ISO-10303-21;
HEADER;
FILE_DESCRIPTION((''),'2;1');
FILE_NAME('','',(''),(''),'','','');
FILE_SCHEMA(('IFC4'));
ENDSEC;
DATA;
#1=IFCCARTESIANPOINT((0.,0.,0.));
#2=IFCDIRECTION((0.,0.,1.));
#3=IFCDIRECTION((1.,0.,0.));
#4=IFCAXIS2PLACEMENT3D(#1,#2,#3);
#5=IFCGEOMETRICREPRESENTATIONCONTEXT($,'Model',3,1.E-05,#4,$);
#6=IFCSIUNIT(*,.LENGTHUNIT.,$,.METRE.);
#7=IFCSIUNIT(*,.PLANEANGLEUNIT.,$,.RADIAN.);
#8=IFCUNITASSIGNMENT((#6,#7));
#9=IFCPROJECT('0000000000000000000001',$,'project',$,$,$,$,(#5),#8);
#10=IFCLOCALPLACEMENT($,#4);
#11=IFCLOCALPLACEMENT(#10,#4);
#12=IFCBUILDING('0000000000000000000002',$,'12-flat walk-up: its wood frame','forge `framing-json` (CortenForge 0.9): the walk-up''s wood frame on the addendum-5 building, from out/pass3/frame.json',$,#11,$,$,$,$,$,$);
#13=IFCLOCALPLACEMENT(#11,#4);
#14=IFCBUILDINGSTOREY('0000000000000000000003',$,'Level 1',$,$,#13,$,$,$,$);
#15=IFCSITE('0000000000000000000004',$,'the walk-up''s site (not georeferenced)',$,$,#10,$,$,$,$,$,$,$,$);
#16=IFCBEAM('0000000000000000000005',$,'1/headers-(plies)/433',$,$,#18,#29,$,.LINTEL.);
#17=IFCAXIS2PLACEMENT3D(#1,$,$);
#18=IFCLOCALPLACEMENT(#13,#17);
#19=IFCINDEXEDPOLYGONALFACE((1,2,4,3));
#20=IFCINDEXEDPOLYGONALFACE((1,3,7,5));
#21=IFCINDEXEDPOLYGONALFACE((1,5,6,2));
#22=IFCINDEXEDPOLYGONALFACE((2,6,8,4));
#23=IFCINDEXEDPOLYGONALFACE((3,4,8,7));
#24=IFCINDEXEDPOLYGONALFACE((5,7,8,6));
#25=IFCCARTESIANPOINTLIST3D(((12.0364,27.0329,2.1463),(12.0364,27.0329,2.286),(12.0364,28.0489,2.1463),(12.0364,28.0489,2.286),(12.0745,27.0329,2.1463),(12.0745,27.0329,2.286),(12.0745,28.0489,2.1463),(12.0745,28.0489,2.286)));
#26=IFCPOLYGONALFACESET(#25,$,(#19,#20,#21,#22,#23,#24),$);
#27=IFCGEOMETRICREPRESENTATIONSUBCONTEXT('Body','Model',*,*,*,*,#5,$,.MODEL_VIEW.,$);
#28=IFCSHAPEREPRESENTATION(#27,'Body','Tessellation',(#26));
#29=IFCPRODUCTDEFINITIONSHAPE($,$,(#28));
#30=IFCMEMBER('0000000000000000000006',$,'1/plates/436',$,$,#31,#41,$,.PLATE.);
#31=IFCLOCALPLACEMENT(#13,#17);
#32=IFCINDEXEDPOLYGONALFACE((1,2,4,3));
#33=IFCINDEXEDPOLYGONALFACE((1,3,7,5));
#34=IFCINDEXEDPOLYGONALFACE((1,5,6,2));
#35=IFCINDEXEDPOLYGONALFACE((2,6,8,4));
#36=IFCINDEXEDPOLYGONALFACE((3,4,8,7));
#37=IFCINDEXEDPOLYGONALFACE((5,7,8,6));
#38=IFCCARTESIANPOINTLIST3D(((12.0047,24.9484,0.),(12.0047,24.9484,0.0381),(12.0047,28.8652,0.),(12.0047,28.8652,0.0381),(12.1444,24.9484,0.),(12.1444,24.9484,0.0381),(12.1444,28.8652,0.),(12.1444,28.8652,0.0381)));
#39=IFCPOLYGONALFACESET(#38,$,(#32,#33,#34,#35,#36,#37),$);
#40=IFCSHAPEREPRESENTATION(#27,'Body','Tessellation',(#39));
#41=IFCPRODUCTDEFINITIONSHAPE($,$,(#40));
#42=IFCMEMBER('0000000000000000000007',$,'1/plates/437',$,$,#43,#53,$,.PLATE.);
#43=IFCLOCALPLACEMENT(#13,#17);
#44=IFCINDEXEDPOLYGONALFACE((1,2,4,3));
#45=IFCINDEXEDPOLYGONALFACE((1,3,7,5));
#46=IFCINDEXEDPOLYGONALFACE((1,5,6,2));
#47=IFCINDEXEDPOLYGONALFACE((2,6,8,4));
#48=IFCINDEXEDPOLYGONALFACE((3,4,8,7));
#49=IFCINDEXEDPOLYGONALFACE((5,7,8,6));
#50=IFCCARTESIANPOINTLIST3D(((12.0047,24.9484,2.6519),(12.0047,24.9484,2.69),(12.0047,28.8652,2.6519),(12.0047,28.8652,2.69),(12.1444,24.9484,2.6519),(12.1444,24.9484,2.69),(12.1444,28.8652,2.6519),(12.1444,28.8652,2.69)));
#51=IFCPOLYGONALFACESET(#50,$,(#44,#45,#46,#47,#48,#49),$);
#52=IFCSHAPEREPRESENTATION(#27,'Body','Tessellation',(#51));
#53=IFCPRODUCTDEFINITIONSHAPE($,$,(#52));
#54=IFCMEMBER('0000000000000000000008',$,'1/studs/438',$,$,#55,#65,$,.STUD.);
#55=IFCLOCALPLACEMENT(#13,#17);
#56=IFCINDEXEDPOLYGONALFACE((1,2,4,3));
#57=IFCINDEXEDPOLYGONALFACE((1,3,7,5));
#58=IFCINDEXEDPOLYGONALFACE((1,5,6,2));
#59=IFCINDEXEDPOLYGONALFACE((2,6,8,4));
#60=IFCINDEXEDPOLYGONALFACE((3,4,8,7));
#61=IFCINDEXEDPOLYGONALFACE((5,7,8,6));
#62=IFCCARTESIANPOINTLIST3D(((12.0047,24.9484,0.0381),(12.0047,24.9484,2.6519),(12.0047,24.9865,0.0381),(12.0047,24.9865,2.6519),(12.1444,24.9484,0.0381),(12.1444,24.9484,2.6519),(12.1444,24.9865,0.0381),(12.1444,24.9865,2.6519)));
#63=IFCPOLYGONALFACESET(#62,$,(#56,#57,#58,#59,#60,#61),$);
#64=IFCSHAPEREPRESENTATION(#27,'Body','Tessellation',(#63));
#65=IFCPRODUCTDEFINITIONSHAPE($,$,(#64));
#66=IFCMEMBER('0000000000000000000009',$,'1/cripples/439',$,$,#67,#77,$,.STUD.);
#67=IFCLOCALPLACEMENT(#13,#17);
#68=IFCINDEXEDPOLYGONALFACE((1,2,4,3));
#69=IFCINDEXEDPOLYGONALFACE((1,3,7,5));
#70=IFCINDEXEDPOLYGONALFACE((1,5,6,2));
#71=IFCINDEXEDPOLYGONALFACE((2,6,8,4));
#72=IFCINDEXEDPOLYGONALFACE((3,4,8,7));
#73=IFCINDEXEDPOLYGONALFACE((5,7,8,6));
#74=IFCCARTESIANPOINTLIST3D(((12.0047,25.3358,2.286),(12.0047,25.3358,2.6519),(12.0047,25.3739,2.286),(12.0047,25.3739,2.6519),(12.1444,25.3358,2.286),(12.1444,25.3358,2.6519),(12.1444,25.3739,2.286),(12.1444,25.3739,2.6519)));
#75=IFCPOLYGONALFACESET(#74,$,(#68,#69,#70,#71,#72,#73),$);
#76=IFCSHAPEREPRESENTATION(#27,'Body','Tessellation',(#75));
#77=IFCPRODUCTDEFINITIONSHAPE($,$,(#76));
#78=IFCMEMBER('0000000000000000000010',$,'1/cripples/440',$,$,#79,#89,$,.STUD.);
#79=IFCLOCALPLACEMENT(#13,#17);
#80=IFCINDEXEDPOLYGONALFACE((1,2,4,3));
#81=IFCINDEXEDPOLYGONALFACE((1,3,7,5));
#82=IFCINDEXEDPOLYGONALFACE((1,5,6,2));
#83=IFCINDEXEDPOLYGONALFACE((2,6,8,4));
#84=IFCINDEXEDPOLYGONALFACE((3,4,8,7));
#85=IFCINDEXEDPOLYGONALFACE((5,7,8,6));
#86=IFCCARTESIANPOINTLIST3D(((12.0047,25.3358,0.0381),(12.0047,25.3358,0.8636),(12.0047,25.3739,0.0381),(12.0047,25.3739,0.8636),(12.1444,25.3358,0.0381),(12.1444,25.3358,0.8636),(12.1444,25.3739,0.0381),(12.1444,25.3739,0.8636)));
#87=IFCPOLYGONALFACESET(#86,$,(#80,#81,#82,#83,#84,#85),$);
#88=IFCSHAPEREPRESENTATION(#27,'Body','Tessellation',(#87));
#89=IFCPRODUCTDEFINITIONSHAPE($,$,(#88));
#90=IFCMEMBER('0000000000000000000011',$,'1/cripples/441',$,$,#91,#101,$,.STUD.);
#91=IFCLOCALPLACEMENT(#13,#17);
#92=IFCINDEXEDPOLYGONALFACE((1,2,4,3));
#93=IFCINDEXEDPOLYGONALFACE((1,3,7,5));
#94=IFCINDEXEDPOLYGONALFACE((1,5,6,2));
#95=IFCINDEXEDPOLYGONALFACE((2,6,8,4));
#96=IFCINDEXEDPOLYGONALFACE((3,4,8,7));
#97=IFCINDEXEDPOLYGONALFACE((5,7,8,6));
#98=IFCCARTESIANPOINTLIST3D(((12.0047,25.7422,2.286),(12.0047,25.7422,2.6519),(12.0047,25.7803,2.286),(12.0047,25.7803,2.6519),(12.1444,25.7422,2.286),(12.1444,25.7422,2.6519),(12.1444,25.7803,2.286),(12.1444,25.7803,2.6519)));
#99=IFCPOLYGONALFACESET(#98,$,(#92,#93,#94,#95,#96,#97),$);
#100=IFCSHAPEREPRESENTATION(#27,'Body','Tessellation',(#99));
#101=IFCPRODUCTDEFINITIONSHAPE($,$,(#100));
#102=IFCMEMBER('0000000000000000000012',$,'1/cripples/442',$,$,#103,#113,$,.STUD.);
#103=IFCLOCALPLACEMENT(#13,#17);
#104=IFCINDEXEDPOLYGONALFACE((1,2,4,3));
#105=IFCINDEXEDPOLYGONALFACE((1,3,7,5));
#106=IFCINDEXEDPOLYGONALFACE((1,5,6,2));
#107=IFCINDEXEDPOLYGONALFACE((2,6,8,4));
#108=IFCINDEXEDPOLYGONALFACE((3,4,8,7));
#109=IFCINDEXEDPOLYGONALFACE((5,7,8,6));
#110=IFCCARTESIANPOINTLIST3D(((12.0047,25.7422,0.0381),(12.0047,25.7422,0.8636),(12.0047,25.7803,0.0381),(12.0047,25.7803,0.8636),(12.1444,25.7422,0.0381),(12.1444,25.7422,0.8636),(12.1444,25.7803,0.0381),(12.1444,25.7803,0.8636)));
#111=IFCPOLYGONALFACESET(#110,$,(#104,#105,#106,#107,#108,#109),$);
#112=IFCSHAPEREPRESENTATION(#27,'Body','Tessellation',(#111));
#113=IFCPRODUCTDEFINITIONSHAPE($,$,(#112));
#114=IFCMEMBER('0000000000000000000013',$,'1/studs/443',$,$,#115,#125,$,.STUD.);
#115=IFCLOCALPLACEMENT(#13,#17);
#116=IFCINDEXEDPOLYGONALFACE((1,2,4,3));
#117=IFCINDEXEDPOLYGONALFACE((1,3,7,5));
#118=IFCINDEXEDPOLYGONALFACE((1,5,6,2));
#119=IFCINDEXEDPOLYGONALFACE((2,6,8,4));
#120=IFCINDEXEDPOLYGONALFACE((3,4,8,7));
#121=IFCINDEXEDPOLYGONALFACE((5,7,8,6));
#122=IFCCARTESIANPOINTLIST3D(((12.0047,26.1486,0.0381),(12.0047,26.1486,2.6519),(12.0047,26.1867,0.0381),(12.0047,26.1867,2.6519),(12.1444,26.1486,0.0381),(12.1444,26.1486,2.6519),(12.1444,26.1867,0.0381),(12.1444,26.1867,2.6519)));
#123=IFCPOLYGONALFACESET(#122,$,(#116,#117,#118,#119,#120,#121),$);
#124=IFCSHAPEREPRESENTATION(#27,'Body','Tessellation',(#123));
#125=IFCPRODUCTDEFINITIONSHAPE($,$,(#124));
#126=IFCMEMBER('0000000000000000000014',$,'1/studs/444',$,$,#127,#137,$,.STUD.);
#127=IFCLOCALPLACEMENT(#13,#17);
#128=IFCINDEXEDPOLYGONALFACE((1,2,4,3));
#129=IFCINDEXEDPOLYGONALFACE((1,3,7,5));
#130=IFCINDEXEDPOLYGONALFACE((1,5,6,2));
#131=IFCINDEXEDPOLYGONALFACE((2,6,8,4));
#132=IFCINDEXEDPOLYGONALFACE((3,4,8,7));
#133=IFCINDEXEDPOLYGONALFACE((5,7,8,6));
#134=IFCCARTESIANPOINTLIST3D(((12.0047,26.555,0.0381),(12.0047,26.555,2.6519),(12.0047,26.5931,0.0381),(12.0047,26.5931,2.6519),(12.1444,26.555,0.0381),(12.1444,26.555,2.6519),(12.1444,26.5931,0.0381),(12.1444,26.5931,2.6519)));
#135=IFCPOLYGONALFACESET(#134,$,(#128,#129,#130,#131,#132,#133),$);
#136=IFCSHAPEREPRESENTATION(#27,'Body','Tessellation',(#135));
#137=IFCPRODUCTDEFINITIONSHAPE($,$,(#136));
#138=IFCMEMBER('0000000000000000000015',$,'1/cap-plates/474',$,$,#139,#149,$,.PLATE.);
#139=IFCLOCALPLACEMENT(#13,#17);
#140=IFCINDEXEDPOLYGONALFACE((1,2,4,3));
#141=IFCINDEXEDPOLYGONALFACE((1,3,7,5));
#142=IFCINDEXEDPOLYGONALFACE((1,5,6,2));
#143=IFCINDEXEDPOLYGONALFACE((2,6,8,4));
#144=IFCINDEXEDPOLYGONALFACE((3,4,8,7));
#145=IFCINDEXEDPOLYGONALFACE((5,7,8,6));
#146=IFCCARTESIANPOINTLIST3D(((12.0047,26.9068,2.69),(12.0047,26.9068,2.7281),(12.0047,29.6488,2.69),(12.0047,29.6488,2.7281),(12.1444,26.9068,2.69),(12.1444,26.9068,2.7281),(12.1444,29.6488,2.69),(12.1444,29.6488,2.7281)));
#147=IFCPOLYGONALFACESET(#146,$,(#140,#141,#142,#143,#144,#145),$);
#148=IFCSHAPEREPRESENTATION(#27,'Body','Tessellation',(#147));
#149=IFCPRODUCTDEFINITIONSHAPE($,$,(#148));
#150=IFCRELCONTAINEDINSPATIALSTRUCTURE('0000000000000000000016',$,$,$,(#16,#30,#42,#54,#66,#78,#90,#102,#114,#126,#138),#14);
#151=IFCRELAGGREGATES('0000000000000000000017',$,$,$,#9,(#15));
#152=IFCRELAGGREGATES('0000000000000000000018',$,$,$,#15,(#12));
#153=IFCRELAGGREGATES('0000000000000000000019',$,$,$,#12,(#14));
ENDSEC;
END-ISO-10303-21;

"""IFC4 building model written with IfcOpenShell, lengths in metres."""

from ifc_helpers import new_model, si_unit, frame, frame_2d, origin, origin_with_axes, place, context, subcontext, project, spatial, rectangle, extrude, element, save


model = new_model("IFC4")

# Units and contexts
model_context = context("Model", 3, precision=1e-05, world=origin_with_axes())
body_context = subcontext(model_context, "Body", "Model", "MODEL_VIEW")
ifc_project = project(units=[si_unit("LENGTHUNIT", "METRE"), si_unit("PLANEANGLEUNIT", "RADIAN")], contexts=[model_context])

# Site, building, storey
site_placement = place(None, origin_with_axes())
site = spatial("IfcSite", under=ifc_project, at=site_placement, Name="the walk-up's site (not georeferenced)")
building_placement = place(site_placement, origin_with_axes())
building = spatial("IfcBuilding", under=site, at=building_placement, Name="12-flat walk-up: its wood frame", Description="forge `framing-json` (CortenForge 0.9): the walk-up's wood frame on the addendum-5 building, from out/pass3/frame.json")
storey_placement = place(building_placement, origin_with_axes())
storey = spatial("IfcBuildingStorey", under=building, at=storey_placement, Name="Level 1")

# Beam
beam_placement = place(storey_placement, frame((12.0364, 27.0329, 2.1463), z_axis=(0.0, 0.0, 1.0), x_axis=(1.0, 0.0, 0.0)))
element("IfcBeam", 1, at=beam_placement, inside=storey, Name="1/headers-(plies)/433", PredefinedType="LINTEL", context=body_context, shape_type="SweptSolid", body=[
    extrude(rectangle(XDim=0.0381, YDim=1.016, at=frame_2d((0.0191, 0.508))), origin(), (0.0, 0.0, 1.0), 0.1397),
])

# Members
member_1_placement = place(storey_placement, frame((12.0047, 24.9484, 0.0), z_axis=(0.0, 0.0, 1.0), x_axis=(1.0, 0.0, 0.0)))
element("IfcMember", 2, at=member_1_placement, inside=storey, Name="1/plates/436", PredefinedType="PLATE", context=body_context, shape_type="SweptSolid", body=[
    extrude(rectangle(XDim=0.1397, YDim=3.9168, at=frame_2d((0.0698, 1.9584))), origin(), (0.0, 0.0, 1.0), 0.0381),
])
member_2_placement = place(storey_placement, frame((12.0047, 24.9484, 2.6519), z_axis=(0.0, 0.0, 1.0), x_axis=(1.0, 0.0, 0.0)))
element("IfcMember", 3, at=member_2_placement, inside=storey, Name="1/plates/437", PredefinedType="PLATE", context=body_context, shape_type="SweptSolid", body=[
    extrude(rectangle(XDim=0.1397, YDim=3.9168, at=frame_2d((0.0698, 1.9584))), origin(), (0.0, 0.0, 1.0), 0.0381),
])
member_3_placement = place(storey_placement, frame((12.0047, 24.9484, 0.0381), z_axis=(0.0, 0.0, 1.0), x_axis=(1.0, 0.0, 0.0)))
element("IfcMember", 4, at=member_3_placement, inside=storey, Name="1/studs/438", PredefinedType="STUD", context=body_context, shape_type="SweptSolid", body=[
    extrude(rectangle(XDim=0.1397, YDim=0.0381, at=frame_2d((0.0698, 0.0191))), origin(), (0.0, 0.0, 1.0), 2.6138),
])
member_4_placement = place(storey_placement, frame((12.0047, 25.3358, 2.286), z_axis=(0.0, 0.0, 1.0), x_axis=(1.0, 0.0, 0.0)))
element("IfcMember", 5, at=member_4_placement, inside=storey, Name="1/cripples/439", PredefinedType="STUD", context=body_context, shape_type="SweptSolid", body=[
    extrude(rectangle(XDim=0.1397, YDim=0.0381, at=frame_2d((0.0698, 0.0191))), origin(), (0.0, 0.0, 1.0), 0.3659),
])
member_5_placement = place(storey_placement, frame((12.0047, 25.3358, 0.0381), z_axis=(0.0, 0.0, 1.0), x_axis=(1.0, 0.0, 0.0)))
element("IfcMember", 6, at=member_5_placement, inside=storey, Name="1/cripples/440", PredefinedType="STUD", context=body_context, shape_type="SweptSolid", body=[
    extrude(rectangle(XDim=0.1397, YDim=0.0381, at=frame_2d((0.0698, 0.0191))), origin(), (0.0, 0.0, 1.0), 0.8255),
])
member_6_placement = place(storey_placement, frame((12.0047, 25.7422, 2.286), z_axis=(0.0, 0.0, 1.0), x_axis=(1.0, 0.0, 0.0)))
element("IfcMember", 7, at=member_6_placement, inside=storey, Name="1/cripples/441", PredefinedType="STUD", context=body_context, shape_type="SweptSolid", body=[
    extrude(rectangle(XDim=0.1397, YDim=0.0381, at=frame_2d((0.0698, 0.0191))), origin(), (0.0, 0.0, 1.0), 0.3659),
])
member_7_placement = place(storey_placement, frame((12.0047, 25.7422, 0.0381), z_axis=(0.0, 0.0, 1.0), x_axis=(1.0, 0.0, 0.0)))
element("IfcMember", 8, at=member_7_placement, inside=storey, Name="1/cripples/442", PredefinedType="STUD", context=body_context, shape_type="SweptSolid", body=[
    extrude(rectangle(XDim=0.1397, YDim=0.0381, at=frame_2d((0.0698, 0.0191))), origin(), (0.0, 0.0, 1.0), 0.8255),
])
for number, where, z_axis, x_axis, name in (
    (9, (12.0047, 26.1486, 0.0381), (0.0, 0.0, 1.0), (1.0, 0.0, 0.0), "1/studs/443"),
    (10, (12.0047, 26.555, 0.0381), (0.0, 0.0, 1.0), (1.0, 0.0, 0.0), "1/studs/444"),
):
    element("IfcMember", number, at=place(storey_placement, frame(where, z_axis=z_axis, x_axis=x_axis)), inside=storey, Name=name, PredefinedType="STUD", context=body_context, shape_type="SweptSolid", body=[
        extrude(rectangle(XDim=0.1397, YDim=0.0381, at=frame_2d((0.0698, 0.0191))), origin(), (0.0, 0.0, 1.0), 2.6138),
    ])
member_8_placement = place(storey_placement, frame((12.0047, 26.9068, 2.69), z_axis=(0.0, 0.0, 1.0), x_axis=(1.0, 0.0, 0.0)))
element("IfcMember", 11, at=member_8_placement, inside=storey, Name="1/cap-plates/474", PredefinedType="PLATE", context=body_context, shape_type="SweptSolid", body=[
    extrude(rectangle(XDim=0.1397, YDim=2.742, at=frame_2d((0.0698, 1.371))), origin(), (0.0, 0.0, 1.0), 0.0381),
])

save(model, "model.ifc")
